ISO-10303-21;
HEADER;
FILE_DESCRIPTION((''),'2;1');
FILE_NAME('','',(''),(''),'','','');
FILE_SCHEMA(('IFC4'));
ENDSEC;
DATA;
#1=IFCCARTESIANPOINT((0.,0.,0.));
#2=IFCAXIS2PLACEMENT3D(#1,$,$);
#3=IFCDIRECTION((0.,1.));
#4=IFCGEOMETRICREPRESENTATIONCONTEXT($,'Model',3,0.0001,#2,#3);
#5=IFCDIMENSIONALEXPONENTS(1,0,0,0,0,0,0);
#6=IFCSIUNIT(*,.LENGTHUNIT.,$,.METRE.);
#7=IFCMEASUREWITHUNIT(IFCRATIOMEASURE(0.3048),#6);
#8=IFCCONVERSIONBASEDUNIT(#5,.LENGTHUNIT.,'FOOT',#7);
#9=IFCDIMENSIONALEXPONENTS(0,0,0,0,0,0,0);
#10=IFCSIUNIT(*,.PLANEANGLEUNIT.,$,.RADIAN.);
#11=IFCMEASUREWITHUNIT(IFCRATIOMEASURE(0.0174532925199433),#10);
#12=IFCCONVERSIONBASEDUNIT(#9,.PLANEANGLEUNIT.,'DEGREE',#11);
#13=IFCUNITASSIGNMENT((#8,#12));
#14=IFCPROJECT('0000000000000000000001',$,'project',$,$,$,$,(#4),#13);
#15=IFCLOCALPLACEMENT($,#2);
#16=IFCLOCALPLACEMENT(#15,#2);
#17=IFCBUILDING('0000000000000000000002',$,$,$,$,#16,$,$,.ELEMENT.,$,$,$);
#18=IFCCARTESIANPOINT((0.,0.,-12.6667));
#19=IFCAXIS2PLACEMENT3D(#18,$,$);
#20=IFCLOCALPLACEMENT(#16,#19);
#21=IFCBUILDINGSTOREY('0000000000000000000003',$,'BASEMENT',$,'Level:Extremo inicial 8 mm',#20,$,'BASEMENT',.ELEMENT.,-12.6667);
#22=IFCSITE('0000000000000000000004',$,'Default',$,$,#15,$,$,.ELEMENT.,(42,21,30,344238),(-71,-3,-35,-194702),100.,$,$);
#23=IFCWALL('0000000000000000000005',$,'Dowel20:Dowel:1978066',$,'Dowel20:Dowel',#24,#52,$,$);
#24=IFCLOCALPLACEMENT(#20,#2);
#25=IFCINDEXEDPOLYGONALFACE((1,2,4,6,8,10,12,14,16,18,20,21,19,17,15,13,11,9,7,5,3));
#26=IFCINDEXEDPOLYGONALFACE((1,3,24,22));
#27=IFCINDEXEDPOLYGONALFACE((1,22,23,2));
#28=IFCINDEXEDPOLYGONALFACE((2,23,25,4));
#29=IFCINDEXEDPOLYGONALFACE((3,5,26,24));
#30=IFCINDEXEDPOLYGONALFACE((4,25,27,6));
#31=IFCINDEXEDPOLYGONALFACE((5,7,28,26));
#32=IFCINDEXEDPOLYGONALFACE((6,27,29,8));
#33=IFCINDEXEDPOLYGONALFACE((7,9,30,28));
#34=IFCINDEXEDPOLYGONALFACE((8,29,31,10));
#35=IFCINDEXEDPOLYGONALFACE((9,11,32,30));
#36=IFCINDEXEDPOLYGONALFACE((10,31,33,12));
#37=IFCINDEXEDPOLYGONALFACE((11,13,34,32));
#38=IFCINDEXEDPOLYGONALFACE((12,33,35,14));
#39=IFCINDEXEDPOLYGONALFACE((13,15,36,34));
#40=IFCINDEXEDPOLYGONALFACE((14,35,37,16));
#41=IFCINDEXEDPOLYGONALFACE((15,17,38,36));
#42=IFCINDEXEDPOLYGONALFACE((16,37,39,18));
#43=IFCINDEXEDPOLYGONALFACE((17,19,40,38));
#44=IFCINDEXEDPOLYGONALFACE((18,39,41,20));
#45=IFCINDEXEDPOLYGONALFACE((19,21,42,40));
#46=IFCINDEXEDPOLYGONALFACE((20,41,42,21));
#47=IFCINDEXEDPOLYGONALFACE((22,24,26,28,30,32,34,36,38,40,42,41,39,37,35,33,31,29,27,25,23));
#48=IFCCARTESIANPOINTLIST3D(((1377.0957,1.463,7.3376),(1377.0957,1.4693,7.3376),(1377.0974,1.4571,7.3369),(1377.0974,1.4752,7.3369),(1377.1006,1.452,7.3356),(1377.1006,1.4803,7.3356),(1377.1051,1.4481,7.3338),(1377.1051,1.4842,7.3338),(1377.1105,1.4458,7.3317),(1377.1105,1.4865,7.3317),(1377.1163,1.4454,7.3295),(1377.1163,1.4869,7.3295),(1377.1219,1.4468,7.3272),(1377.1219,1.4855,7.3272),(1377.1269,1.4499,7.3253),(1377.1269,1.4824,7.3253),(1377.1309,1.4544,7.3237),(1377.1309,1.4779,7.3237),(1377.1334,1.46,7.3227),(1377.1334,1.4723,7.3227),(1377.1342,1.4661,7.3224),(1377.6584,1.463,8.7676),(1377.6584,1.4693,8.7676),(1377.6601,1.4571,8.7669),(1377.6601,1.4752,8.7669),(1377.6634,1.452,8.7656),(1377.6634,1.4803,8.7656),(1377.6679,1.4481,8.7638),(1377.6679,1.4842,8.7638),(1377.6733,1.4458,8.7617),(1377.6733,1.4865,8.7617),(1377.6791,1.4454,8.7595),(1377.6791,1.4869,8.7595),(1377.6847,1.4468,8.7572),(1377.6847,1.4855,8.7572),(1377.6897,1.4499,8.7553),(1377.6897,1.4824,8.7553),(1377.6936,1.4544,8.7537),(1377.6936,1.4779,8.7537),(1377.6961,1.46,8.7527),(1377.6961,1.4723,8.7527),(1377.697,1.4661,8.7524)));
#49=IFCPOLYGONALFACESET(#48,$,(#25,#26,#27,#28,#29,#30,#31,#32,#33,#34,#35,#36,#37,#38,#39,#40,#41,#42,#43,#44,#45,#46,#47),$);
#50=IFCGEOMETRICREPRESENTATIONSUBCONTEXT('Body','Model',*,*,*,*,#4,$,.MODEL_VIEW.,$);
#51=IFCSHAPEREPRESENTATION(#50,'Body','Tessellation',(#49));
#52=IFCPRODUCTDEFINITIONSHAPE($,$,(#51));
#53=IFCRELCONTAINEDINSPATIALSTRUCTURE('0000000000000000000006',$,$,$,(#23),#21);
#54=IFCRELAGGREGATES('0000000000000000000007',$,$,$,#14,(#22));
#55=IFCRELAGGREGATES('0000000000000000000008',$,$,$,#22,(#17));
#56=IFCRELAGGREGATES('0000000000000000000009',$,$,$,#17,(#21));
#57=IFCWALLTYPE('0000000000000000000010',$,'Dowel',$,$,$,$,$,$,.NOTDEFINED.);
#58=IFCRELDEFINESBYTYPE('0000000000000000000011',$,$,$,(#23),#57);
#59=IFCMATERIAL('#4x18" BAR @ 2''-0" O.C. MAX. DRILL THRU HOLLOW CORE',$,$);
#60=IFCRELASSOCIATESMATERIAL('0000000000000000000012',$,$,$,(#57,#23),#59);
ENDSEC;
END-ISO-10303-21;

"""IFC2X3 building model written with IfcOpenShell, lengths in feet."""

from ifc_helpers import new_model, entity, si_unit, converted_unit, direction, frame, origin, origin_2d_with_axis, place, context, subcontext, project, spatial, circle, extrude, material, type_object, element, save


model = new_model("IFC2X3")

# Units and contexts
model_context = context("Model", 3, precision=0.0001, world=origin(), true_north=direction((0.0, 1.0)))
body_context = subcontext(model_context, "Body", "Model", "MODEL_VIEW")
ifc_project = project(units=[converted_unit("LENGTHUNIT", "FOOT", entity("IfcRatioMeasure", 0.3048), si_unit("LENGTHUNIT", "METRE"), dimensions=[1, 0, 0, 0, 0, 0, 0]), converted_unit("PLANEANGLEUNIT", "DEGREE", entity("IfcRatioMeasure", 0.0174532925199433), si_unit("PLANEANGLEUNIT", "RADIAN"), dimensions=[0, 0, 0, 0, 0, 0, 0])], contexts=[model_context])

# Site, building, storey
site_placement = place(None, origin())
site = spatial("IfcSite", under=ifc_project, at=site_placement, Name="Default", CompositionType="ELEMENT", RefLatitude=(42, 21, 30, 344238), RefLongitude=(-71, -3, -35, -194702), RefElevation=100.0)
building_placement = place(site_placement, origin())
building = spatial("IfcBuilding", under=site, at=building_placement, CompositionType="ELEMENT")
storey_placement = place(building_placement, frame((0.0, 0.0, -12.6667)))
storey = spatial("IfcBuildingStorey", under=building, at=storey_placement, Name="BASEMENT", ObjectType="Level:Extremo inicial 8 mm", LongName="BASEMENT", CompositionType="ELEMENT", Elevation=-12.6667)

# Wall
ifc_material_1 = material(Name="#4x18\" BAR @ 2'-0\" O.C. MAX. DRILL THRU HOLLOW CORE")
wall_type_1 = type_object("IfcWallType", Name="Dowel", PredefinedType="NOTDEFINED", material=ifc_material_1)
wall_1_placement = place(storey_placement, frame((1377.0955, 1.4453, 7.3224)))
element("IfcWall", 1, at=wall_1_placement, inside=storey, type_object=wall_type_1, material=ifc_material_1, Name="Dowel20:Dowel:1978066", ObjectType="Dowel20:Dowel", context=body_context, shape_type="SweptSolid", body=[
    extrude(circle(Radius=0.0208, at=origin_2d_with_axis()), frame((0.0194, 0.0208, 0.0076), z_axis=(0.36621, 0.0, 0.930532), x_axis=(0.930532, 0.0, -0.36621)), (0.0, 0.0, 1.0), 1.5368),
])

save(model, "model.ifc")
